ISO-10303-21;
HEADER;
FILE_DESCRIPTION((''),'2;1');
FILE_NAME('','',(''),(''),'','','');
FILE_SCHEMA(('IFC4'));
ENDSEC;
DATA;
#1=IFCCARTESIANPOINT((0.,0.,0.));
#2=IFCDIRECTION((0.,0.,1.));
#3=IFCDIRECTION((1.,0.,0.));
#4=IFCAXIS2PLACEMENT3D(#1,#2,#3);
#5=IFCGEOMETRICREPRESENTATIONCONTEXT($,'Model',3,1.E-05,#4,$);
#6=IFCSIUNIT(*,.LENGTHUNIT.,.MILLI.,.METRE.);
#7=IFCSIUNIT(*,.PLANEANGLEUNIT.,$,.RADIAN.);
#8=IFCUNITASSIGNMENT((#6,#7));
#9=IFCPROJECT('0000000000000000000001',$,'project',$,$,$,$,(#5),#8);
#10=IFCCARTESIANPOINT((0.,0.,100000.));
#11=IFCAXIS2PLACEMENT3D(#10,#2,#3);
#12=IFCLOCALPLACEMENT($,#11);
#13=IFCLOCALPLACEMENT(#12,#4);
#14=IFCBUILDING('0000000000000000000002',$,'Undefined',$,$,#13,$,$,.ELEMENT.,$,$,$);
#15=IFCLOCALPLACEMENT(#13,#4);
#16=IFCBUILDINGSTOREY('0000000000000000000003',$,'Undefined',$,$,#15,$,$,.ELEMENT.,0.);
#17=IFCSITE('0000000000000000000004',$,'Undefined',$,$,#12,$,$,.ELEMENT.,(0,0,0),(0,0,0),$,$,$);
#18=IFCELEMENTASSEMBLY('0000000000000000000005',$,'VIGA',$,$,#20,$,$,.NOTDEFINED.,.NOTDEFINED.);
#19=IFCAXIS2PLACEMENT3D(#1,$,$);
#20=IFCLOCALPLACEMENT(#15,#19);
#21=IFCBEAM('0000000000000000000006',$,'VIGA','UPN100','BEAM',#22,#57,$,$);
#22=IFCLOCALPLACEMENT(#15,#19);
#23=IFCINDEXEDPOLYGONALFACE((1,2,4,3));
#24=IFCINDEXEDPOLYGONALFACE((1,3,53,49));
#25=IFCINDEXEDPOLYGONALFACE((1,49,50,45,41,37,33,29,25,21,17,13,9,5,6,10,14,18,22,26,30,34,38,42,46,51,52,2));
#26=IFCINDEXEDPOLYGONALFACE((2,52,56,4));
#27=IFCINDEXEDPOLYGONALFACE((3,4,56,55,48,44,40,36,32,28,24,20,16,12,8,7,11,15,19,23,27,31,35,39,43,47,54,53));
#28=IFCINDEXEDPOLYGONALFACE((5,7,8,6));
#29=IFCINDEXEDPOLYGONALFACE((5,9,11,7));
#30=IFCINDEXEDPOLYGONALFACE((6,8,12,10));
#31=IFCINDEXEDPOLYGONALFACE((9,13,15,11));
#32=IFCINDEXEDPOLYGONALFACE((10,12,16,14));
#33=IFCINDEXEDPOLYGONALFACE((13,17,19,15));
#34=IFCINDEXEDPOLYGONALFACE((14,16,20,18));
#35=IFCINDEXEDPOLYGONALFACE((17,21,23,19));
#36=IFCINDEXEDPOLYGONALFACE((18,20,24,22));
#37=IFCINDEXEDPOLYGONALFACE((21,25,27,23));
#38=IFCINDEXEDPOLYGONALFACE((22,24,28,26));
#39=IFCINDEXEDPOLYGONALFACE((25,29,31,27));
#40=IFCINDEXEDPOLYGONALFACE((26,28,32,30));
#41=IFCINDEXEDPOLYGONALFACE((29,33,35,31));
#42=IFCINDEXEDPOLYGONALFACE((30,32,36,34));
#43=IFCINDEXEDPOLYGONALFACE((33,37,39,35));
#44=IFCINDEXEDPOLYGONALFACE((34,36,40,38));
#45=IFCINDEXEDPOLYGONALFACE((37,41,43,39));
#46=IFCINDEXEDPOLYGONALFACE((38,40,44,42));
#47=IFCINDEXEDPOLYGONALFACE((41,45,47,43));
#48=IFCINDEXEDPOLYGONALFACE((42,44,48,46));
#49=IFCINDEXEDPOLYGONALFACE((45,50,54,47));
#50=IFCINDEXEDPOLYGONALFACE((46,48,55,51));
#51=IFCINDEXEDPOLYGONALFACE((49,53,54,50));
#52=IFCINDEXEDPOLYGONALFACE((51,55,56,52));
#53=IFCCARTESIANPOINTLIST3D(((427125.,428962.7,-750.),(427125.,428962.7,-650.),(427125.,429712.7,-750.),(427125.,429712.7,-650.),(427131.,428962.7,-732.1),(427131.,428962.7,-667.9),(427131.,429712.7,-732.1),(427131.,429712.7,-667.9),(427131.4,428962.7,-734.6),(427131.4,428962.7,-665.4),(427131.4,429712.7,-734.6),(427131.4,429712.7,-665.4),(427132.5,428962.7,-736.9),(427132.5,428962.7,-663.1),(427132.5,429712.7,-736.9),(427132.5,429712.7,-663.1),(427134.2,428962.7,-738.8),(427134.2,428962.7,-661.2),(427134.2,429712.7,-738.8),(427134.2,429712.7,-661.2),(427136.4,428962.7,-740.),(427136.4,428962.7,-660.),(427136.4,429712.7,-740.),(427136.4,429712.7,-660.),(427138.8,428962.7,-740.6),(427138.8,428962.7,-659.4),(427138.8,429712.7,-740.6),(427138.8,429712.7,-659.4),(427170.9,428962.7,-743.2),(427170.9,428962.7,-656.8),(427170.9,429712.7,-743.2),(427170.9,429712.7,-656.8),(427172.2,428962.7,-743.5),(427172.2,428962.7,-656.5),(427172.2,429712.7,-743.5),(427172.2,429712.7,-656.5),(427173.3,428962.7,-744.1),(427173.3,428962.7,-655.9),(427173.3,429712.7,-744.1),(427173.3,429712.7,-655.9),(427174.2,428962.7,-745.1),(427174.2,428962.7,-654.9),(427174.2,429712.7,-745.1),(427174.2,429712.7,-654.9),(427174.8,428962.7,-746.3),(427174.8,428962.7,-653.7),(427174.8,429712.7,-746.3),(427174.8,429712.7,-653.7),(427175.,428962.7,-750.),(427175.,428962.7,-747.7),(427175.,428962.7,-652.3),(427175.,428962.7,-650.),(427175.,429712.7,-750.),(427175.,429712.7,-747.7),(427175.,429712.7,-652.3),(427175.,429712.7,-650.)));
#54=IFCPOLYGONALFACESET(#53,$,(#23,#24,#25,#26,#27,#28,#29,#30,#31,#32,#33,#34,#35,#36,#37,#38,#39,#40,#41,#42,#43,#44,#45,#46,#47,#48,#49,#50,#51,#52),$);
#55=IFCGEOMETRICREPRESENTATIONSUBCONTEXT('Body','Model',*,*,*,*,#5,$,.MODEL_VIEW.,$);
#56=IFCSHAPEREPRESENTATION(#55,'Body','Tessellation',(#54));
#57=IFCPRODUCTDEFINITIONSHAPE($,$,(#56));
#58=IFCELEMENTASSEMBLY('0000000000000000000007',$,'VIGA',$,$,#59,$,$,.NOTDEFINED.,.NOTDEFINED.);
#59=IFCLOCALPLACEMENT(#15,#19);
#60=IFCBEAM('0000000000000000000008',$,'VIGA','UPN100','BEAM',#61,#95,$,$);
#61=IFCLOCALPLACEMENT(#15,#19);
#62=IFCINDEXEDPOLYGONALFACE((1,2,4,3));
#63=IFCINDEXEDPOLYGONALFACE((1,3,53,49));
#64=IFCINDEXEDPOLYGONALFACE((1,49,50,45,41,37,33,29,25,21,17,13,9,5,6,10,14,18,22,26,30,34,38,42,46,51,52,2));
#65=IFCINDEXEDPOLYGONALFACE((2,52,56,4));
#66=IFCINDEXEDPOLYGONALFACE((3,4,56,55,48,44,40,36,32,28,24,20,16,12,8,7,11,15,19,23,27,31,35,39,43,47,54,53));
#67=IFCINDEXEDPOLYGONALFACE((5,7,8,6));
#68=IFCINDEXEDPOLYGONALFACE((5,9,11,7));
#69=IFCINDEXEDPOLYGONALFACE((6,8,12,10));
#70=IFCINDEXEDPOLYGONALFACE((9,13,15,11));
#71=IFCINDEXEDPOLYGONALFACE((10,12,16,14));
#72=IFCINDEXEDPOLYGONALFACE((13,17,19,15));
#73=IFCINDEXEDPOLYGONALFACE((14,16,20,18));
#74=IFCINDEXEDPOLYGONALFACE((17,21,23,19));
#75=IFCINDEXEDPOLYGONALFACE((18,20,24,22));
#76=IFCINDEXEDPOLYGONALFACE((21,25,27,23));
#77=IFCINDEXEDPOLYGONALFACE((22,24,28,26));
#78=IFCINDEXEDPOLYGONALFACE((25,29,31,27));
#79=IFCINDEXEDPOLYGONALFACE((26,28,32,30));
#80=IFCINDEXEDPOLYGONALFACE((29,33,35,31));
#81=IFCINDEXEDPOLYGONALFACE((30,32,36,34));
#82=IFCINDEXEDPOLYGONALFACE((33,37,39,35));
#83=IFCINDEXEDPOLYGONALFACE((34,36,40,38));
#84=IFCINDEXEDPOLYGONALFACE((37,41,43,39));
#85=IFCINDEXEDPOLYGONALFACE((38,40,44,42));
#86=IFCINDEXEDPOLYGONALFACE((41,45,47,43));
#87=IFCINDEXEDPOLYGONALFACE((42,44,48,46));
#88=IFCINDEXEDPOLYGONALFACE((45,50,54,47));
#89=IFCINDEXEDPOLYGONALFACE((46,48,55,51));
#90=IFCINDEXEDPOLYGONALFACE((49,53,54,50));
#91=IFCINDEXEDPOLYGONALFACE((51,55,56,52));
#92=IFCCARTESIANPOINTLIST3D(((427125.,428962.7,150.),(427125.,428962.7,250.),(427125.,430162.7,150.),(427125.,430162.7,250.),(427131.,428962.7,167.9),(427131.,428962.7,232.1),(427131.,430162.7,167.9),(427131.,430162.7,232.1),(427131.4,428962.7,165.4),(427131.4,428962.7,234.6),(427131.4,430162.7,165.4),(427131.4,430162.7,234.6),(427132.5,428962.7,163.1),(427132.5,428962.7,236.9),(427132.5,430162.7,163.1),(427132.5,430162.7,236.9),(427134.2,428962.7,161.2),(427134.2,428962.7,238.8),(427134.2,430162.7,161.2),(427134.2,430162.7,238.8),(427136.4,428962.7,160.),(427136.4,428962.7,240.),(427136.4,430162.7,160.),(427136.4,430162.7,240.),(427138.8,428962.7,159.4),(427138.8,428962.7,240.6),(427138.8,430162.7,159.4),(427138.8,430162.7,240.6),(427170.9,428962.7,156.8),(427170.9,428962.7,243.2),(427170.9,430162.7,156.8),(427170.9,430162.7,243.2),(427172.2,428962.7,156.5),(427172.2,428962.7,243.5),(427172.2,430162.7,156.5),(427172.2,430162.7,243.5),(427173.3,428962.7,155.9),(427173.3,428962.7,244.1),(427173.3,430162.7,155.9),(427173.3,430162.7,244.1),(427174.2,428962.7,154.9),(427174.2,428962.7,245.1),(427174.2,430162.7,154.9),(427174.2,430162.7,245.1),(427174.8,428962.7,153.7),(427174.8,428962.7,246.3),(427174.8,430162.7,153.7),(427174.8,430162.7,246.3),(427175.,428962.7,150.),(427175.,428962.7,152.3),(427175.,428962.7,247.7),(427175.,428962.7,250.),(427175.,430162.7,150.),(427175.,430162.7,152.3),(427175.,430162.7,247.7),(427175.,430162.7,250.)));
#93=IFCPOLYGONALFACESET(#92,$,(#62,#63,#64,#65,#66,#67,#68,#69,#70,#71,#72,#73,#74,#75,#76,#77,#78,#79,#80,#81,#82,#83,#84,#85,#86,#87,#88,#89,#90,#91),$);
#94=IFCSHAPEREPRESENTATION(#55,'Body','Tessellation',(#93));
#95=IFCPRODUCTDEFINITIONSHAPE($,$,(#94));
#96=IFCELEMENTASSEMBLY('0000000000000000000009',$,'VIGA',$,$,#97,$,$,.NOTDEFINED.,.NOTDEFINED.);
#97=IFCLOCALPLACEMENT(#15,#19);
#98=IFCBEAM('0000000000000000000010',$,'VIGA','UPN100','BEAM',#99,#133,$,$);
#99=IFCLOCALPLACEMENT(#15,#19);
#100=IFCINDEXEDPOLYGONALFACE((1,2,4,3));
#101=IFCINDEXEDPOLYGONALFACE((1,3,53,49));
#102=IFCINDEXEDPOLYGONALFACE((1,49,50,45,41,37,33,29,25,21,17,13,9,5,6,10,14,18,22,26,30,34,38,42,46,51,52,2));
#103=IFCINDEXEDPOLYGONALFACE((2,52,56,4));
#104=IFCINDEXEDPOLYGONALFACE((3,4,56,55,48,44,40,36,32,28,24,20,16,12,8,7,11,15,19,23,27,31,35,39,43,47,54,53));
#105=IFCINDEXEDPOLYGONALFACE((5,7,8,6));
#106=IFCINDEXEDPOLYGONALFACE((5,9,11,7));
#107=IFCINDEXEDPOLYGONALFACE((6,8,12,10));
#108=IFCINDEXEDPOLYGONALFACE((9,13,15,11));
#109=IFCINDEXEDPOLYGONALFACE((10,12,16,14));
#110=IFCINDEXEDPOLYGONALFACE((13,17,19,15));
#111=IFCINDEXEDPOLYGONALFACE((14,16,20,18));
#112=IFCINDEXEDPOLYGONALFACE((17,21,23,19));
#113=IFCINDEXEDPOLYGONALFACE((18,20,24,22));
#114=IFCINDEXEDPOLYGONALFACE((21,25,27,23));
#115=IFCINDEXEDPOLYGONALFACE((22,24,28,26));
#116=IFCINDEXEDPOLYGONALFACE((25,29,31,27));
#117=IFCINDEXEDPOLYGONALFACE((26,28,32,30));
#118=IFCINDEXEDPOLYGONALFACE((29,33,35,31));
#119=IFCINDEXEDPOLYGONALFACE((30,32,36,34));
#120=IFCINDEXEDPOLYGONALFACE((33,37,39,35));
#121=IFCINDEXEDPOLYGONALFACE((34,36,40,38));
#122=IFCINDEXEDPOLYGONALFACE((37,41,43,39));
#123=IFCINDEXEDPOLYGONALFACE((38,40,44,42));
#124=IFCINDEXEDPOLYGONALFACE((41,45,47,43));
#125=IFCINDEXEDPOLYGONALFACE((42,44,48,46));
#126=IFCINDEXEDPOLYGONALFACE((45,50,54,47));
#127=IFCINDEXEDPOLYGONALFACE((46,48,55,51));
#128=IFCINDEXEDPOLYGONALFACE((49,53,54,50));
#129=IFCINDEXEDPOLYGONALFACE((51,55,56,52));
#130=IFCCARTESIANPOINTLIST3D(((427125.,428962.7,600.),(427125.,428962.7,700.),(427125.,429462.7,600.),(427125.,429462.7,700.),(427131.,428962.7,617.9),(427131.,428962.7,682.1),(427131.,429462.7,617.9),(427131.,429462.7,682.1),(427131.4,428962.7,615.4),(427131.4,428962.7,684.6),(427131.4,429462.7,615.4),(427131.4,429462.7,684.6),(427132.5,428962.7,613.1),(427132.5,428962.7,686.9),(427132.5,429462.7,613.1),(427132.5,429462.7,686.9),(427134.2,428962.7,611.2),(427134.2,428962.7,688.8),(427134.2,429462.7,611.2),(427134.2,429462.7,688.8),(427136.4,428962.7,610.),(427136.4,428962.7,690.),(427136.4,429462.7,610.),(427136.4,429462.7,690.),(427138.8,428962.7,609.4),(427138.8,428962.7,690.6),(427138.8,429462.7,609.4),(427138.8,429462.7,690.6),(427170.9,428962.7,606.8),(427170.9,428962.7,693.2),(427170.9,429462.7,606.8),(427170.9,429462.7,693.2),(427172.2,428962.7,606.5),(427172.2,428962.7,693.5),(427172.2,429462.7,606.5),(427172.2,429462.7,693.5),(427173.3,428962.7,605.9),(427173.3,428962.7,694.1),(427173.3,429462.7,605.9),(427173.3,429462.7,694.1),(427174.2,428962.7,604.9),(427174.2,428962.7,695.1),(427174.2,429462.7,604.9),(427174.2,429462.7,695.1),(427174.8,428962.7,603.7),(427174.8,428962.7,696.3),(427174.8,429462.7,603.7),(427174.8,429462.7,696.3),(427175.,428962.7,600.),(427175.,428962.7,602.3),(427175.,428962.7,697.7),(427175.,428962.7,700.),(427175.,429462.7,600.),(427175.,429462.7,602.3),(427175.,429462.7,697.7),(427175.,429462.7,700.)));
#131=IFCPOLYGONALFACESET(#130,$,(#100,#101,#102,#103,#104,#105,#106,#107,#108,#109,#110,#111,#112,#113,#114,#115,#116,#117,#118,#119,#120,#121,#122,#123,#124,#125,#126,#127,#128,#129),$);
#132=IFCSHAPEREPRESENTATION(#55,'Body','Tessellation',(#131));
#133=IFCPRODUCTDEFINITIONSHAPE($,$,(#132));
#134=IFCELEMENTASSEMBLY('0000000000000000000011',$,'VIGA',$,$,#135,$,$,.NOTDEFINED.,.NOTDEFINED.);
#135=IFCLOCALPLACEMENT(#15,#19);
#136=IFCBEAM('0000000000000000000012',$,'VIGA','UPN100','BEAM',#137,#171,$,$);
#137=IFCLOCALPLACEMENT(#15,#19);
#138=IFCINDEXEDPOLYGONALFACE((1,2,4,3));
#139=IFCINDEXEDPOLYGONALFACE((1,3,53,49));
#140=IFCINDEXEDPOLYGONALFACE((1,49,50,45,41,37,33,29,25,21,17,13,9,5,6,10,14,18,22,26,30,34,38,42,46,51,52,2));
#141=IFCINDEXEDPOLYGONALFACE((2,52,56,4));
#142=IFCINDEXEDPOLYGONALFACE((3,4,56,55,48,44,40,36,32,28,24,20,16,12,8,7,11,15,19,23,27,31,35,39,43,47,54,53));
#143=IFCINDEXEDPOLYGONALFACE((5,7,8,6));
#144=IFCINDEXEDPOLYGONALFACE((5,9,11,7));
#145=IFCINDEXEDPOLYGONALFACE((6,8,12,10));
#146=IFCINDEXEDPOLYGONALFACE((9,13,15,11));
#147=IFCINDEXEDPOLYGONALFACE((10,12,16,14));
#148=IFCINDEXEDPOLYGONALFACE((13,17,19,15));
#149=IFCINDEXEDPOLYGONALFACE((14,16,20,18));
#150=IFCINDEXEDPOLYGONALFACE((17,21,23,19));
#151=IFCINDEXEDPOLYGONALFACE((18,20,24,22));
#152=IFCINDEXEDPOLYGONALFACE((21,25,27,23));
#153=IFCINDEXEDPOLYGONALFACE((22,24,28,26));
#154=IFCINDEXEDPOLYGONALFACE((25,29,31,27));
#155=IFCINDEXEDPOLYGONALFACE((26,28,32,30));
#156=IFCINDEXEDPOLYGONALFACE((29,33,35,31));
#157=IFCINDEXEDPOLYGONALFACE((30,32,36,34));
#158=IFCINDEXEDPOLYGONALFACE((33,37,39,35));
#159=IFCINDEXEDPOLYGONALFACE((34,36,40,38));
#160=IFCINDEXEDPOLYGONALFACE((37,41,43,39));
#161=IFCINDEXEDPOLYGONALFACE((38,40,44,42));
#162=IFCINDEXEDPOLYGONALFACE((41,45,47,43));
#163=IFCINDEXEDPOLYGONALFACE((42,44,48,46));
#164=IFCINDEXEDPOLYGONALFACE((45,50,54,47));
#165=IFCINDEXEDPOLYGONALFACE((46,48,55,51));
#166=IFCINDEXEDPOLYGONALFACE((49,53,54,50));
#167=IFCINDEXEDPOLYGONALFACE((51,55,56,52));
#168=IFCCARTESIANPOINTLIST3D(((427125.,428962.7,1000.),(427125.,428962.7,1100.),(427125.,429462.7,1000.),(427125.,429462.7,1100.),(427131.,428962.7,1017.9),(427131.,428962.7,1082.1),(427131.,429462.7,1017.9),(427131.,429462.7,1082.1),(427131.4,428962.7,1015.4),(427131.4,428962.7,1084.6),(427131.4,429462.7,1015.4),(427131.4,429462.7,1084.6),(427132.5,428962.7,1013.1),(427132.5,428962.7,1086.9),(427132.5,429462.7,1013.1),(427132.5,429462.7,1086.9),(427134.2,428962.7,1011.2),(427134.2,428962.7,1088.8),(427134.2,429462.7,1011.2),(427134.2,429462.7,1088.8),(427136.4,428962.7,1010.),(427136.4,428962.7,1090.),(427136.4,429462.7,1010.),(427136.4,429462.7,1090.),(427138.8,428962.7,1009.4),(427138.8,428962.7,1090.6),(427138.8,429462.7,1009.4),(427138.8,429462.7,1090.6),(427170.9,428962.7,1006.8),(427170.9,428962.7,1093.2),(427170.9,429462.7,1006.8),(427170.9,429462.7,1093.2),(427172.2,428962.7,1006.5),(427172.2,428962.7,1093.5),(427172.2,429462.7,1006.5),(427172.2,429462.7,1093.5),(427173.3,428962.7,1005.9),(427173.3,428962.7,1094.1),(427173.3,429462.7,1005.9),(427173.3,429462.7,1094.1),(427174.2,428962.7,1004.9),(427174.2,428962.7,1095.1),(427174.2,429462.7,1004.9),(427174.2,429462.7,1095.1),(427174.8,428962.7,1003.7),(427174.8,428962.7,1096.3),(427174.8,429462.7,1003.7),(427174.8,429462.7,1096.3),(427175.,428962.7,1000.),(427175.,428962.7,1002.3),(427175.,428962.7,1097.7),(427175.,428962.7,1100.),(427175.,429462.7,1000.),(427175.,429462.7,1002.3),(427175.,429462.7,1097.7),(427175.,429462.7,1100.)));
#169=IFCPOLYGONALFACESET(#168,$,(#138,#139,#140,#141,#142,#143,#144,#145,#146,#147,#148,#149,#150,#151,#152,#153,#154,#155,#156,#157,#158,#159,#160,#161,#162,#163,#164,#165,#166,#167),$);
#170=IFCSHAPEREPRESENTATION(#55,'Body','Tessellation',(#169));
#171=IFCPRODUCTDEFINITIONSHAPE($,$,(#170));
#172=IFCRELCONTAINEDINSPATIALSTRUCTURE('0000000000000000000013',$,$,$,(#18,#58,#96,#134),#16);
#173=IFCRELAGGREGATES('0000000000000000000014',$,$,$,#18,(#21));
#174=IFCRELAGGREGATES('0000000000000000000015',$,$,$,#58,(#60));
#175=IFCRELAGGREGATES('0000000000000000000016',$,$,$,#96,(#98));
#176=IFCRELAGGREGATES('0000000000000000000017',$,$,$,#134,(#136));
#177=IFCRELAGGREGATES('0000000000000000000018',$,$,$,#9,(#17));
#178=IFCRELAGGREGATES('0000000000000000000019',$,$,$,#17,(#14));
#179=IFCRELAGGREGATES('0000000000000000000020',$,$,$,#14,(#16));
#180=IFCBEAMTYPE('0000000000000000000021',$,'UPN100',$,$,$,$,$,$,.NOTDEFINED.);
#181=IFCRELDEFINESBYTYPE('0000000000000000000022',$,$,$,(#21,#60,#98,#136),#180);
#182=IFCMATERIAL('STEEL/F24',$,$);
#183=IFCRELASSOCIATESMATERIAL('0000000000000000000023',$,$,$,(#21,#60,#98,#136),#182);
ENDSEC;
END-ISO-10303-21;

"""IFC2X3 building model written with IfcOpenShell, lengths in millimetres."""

from ifc_helpers import new_model, si_unit, frame, origin_with_axes, origin_2d_with_axis, place, context, subcontext, project, spatial, u_section, extrude, material, type_object, element, aggregate, save


model = new_model("IFC2X3")

# Units and contexts
model_context = context("Model", 3, precision=1e-05, world=origin_with_axes())
body_context = subcontext(model_context, "Body", "Model", "MODEL_VIEW")
ifc_project = project(units=[si_unit("LENGTHUNIT", "METRE", prefix="MILLI"), si_unit("PLANEANGLEUNIT", "RADIAN")], contexts=[model_context])

# Site, building, storey
site_placement = place(None, frame((0.0, 0.0, 100000.0), z_axis=(0.0, 0.0, 1.0), x_axis=(1.0, 0.0, 0.0)))
site = spatial("IfcSite", under=ifc_project, at=site_placement, Name="Undefined", CompositionType="ELEMENT", RefLatitude=(0, 0, 0), RefLongitude=(0, 0, 0))
building_placement = place(site_placement, origin_with_axes())
building = spatial("IfcBuilding", under=site, at=building_placement, Name="Undefined", CompositionType="ELEMENT")
storey_placement = place(building_placement, origin_with_axes())
storey = spatial("IfcBuildingStorey", under=building, at=storey_placement, Name="Undefined", CompositionType="ELEMENT", Elevation=0.0)

# Element assemblies, beams
ifc_material_1 = material(Name="STEEL/F24")
beam_type = type_object("IfcBeamType", Name="UPN100", PredefinedType="NOTDEFINED")
assembly_1_placement = place(storey_placement, origin_with_axes())
assembly_1 = element("IfcElementAssembly", 1, at=assembly_1_placement, inside=storey, Name="VIGA", AssemblyPlace="NOTDEFINED", PredefinedType="NOTDEFINED")
beam_1_placement = place(assembly_1_placement, frame((427150.0, 428962.7, -700.0), z_axis=(0.0, 0.0, 1.0), x_axis=(0.0, 1.0, 0.0)))
beam_1 = element("IfcBeam", 2, at=beam_1_placement, type_object=beam_type, material=ifc_material_1, Name="VIGA", Description="UPN100", ObjectType="BEAM", context=body_context, shape_type="SweptSolid", body=[
    extrude(u_section(Depth=100.0, FlangeWidth=50.0, WebThickness=6.0, FlangeThickness=8.5, FilletRadius=8.5, EdgeRadius=4.5, FlangeSlope=0.07983, at=origin_2d_with_axis()), frame((750.0, 0.0, 0.0), z_axis=(-1.0, 0.0, 0.0), x_axis=(0.0, -1.0, 0.0)), (0.0, 0.0, 1.0), 750.0),
])
aggregate(assembly_1, [beam_1])
assembly_2_placement = place(storey_placement, origin_with_axes())
assembly_2 = element("IfcElementAssembly", 3, at=assembly_2_placement, inside=storey, Name="VIGA", AssemblyPlace="NOTDEFINED", PredefinedType="NOTDEFINED")
beam_2_placement = place(assembly_2_placement, frame((427150.0, 428962.7, 200.0), z_axis=(0.0, 0.0, 1.0), x_axis=(0.0, 1.0, 0.0)))
beam_2 = element("IfcBeam", 4, at=beam_2_placement, type_object=beam_type, material=ifc_material_1, Name="VIGA", Description="UPN100", ObjectType="BEAM", context=body_context, shape_type="SweptSolid", body=[
    extrude(u_section(Depth=100.0, FlangeWidth=50.0, WebThickness=6.0, FlangeThickness=8.5, FilletRadius=8.5, EdgeRadius=4.5, FlangeSlope=0.07983, at=origin_2d_with_axis()), frame((1200.0, 0.0, 0.0), z_axis=(-1.0, 0.0, 0.0), x_axis=(0.0, -1.0, 0.0)), (0.0, 0.0, 1.0), 1200.0),
])
aggregate(assembly_2, [beam_2])
assembly_3_placement = place(storey_placement, origin_with_axes())
assembly_3 = element("IfcElementAssembly", 5, at=assembly_3_placement, inside=storey, Name="VIGA", AssemblyPlace="NOTDEFINED", PredefinedType="NOTDEFINED")
beam_3_placement = place(assembly_3_placement, frame((427150.0, 428962.7, 650.0), z_axis=(0.0, 0.0, 1.0), x_axis=(0.0, 1.0, 0.0)))
beam_3 = element("IfcBeam", 6, at=beam_3_placement, type_object=beam_type, material=ifc_material_1, Name="VIGA", Description="UPN100", ObjectType="BEAM", context=body_context, shape_type="SweptSolid", body=[
    extrude(u_section(Depth=100.0, FlangeWidth=50.0, WebThickness=6.0, FlangeThickness=8.5, FilletRadius=8.5, EdgeRadius=4.5, FlangeSlope=0.07983, at=origin_2d_with_axis()), frame((500.0, 0.0, 0.0), z_axis=(-1.0, 0.0, 0.0), x_axis=(0.0, -1.0, 0.0)), (0.0, 0.0, 1.0), 500.0),
])
aggregate(assembly_3, [beam_3])
assembly_4_placement = place(storey_placement, origin_with_axes())
assembly_4 = element("IfcElementAssembly", 7, at=assembly_4_placement, inside=storey, Name="VIGA", AssemblyPlace="NOTDEFINED", PredefinedType="NOTDEFINED")
beam_4_placement = place(assembly_4_placement, frame((427150.0, 428962.7, 1050.0), z_axis=(0.0, 0.0, 1.0), x_axis=(0.0, 1.0, 0.0)))
beam_4 = element("IfcBeam", 8, at=beam_4_placement, type_object=beam_type, material=ifc_material_1, Name="VIGA", Description="UPN100", ObjectType="BEAM", context=body_context, shape_type="SweptSolid", body=[
    extrude(u_section(Depth=100.0, FlangeWidth=50.0, WebThickness=6.0, FlangeThickness=8.5, FilletRadius=8.5, EdgeRadius=4.5, FlangeSlope=0.07983, at=origin_2d_with_axis()), frame((500.0, 0.0, 0.0), z_axis=(-1.0, 0.0, 0.0), x_axis=(0.0, -1.0, 0.0)), (0.0, 0.0, 1.0), 500.0),
])
aggregate(assembly_4, [beam_4])

save(model, "model.ifc")
